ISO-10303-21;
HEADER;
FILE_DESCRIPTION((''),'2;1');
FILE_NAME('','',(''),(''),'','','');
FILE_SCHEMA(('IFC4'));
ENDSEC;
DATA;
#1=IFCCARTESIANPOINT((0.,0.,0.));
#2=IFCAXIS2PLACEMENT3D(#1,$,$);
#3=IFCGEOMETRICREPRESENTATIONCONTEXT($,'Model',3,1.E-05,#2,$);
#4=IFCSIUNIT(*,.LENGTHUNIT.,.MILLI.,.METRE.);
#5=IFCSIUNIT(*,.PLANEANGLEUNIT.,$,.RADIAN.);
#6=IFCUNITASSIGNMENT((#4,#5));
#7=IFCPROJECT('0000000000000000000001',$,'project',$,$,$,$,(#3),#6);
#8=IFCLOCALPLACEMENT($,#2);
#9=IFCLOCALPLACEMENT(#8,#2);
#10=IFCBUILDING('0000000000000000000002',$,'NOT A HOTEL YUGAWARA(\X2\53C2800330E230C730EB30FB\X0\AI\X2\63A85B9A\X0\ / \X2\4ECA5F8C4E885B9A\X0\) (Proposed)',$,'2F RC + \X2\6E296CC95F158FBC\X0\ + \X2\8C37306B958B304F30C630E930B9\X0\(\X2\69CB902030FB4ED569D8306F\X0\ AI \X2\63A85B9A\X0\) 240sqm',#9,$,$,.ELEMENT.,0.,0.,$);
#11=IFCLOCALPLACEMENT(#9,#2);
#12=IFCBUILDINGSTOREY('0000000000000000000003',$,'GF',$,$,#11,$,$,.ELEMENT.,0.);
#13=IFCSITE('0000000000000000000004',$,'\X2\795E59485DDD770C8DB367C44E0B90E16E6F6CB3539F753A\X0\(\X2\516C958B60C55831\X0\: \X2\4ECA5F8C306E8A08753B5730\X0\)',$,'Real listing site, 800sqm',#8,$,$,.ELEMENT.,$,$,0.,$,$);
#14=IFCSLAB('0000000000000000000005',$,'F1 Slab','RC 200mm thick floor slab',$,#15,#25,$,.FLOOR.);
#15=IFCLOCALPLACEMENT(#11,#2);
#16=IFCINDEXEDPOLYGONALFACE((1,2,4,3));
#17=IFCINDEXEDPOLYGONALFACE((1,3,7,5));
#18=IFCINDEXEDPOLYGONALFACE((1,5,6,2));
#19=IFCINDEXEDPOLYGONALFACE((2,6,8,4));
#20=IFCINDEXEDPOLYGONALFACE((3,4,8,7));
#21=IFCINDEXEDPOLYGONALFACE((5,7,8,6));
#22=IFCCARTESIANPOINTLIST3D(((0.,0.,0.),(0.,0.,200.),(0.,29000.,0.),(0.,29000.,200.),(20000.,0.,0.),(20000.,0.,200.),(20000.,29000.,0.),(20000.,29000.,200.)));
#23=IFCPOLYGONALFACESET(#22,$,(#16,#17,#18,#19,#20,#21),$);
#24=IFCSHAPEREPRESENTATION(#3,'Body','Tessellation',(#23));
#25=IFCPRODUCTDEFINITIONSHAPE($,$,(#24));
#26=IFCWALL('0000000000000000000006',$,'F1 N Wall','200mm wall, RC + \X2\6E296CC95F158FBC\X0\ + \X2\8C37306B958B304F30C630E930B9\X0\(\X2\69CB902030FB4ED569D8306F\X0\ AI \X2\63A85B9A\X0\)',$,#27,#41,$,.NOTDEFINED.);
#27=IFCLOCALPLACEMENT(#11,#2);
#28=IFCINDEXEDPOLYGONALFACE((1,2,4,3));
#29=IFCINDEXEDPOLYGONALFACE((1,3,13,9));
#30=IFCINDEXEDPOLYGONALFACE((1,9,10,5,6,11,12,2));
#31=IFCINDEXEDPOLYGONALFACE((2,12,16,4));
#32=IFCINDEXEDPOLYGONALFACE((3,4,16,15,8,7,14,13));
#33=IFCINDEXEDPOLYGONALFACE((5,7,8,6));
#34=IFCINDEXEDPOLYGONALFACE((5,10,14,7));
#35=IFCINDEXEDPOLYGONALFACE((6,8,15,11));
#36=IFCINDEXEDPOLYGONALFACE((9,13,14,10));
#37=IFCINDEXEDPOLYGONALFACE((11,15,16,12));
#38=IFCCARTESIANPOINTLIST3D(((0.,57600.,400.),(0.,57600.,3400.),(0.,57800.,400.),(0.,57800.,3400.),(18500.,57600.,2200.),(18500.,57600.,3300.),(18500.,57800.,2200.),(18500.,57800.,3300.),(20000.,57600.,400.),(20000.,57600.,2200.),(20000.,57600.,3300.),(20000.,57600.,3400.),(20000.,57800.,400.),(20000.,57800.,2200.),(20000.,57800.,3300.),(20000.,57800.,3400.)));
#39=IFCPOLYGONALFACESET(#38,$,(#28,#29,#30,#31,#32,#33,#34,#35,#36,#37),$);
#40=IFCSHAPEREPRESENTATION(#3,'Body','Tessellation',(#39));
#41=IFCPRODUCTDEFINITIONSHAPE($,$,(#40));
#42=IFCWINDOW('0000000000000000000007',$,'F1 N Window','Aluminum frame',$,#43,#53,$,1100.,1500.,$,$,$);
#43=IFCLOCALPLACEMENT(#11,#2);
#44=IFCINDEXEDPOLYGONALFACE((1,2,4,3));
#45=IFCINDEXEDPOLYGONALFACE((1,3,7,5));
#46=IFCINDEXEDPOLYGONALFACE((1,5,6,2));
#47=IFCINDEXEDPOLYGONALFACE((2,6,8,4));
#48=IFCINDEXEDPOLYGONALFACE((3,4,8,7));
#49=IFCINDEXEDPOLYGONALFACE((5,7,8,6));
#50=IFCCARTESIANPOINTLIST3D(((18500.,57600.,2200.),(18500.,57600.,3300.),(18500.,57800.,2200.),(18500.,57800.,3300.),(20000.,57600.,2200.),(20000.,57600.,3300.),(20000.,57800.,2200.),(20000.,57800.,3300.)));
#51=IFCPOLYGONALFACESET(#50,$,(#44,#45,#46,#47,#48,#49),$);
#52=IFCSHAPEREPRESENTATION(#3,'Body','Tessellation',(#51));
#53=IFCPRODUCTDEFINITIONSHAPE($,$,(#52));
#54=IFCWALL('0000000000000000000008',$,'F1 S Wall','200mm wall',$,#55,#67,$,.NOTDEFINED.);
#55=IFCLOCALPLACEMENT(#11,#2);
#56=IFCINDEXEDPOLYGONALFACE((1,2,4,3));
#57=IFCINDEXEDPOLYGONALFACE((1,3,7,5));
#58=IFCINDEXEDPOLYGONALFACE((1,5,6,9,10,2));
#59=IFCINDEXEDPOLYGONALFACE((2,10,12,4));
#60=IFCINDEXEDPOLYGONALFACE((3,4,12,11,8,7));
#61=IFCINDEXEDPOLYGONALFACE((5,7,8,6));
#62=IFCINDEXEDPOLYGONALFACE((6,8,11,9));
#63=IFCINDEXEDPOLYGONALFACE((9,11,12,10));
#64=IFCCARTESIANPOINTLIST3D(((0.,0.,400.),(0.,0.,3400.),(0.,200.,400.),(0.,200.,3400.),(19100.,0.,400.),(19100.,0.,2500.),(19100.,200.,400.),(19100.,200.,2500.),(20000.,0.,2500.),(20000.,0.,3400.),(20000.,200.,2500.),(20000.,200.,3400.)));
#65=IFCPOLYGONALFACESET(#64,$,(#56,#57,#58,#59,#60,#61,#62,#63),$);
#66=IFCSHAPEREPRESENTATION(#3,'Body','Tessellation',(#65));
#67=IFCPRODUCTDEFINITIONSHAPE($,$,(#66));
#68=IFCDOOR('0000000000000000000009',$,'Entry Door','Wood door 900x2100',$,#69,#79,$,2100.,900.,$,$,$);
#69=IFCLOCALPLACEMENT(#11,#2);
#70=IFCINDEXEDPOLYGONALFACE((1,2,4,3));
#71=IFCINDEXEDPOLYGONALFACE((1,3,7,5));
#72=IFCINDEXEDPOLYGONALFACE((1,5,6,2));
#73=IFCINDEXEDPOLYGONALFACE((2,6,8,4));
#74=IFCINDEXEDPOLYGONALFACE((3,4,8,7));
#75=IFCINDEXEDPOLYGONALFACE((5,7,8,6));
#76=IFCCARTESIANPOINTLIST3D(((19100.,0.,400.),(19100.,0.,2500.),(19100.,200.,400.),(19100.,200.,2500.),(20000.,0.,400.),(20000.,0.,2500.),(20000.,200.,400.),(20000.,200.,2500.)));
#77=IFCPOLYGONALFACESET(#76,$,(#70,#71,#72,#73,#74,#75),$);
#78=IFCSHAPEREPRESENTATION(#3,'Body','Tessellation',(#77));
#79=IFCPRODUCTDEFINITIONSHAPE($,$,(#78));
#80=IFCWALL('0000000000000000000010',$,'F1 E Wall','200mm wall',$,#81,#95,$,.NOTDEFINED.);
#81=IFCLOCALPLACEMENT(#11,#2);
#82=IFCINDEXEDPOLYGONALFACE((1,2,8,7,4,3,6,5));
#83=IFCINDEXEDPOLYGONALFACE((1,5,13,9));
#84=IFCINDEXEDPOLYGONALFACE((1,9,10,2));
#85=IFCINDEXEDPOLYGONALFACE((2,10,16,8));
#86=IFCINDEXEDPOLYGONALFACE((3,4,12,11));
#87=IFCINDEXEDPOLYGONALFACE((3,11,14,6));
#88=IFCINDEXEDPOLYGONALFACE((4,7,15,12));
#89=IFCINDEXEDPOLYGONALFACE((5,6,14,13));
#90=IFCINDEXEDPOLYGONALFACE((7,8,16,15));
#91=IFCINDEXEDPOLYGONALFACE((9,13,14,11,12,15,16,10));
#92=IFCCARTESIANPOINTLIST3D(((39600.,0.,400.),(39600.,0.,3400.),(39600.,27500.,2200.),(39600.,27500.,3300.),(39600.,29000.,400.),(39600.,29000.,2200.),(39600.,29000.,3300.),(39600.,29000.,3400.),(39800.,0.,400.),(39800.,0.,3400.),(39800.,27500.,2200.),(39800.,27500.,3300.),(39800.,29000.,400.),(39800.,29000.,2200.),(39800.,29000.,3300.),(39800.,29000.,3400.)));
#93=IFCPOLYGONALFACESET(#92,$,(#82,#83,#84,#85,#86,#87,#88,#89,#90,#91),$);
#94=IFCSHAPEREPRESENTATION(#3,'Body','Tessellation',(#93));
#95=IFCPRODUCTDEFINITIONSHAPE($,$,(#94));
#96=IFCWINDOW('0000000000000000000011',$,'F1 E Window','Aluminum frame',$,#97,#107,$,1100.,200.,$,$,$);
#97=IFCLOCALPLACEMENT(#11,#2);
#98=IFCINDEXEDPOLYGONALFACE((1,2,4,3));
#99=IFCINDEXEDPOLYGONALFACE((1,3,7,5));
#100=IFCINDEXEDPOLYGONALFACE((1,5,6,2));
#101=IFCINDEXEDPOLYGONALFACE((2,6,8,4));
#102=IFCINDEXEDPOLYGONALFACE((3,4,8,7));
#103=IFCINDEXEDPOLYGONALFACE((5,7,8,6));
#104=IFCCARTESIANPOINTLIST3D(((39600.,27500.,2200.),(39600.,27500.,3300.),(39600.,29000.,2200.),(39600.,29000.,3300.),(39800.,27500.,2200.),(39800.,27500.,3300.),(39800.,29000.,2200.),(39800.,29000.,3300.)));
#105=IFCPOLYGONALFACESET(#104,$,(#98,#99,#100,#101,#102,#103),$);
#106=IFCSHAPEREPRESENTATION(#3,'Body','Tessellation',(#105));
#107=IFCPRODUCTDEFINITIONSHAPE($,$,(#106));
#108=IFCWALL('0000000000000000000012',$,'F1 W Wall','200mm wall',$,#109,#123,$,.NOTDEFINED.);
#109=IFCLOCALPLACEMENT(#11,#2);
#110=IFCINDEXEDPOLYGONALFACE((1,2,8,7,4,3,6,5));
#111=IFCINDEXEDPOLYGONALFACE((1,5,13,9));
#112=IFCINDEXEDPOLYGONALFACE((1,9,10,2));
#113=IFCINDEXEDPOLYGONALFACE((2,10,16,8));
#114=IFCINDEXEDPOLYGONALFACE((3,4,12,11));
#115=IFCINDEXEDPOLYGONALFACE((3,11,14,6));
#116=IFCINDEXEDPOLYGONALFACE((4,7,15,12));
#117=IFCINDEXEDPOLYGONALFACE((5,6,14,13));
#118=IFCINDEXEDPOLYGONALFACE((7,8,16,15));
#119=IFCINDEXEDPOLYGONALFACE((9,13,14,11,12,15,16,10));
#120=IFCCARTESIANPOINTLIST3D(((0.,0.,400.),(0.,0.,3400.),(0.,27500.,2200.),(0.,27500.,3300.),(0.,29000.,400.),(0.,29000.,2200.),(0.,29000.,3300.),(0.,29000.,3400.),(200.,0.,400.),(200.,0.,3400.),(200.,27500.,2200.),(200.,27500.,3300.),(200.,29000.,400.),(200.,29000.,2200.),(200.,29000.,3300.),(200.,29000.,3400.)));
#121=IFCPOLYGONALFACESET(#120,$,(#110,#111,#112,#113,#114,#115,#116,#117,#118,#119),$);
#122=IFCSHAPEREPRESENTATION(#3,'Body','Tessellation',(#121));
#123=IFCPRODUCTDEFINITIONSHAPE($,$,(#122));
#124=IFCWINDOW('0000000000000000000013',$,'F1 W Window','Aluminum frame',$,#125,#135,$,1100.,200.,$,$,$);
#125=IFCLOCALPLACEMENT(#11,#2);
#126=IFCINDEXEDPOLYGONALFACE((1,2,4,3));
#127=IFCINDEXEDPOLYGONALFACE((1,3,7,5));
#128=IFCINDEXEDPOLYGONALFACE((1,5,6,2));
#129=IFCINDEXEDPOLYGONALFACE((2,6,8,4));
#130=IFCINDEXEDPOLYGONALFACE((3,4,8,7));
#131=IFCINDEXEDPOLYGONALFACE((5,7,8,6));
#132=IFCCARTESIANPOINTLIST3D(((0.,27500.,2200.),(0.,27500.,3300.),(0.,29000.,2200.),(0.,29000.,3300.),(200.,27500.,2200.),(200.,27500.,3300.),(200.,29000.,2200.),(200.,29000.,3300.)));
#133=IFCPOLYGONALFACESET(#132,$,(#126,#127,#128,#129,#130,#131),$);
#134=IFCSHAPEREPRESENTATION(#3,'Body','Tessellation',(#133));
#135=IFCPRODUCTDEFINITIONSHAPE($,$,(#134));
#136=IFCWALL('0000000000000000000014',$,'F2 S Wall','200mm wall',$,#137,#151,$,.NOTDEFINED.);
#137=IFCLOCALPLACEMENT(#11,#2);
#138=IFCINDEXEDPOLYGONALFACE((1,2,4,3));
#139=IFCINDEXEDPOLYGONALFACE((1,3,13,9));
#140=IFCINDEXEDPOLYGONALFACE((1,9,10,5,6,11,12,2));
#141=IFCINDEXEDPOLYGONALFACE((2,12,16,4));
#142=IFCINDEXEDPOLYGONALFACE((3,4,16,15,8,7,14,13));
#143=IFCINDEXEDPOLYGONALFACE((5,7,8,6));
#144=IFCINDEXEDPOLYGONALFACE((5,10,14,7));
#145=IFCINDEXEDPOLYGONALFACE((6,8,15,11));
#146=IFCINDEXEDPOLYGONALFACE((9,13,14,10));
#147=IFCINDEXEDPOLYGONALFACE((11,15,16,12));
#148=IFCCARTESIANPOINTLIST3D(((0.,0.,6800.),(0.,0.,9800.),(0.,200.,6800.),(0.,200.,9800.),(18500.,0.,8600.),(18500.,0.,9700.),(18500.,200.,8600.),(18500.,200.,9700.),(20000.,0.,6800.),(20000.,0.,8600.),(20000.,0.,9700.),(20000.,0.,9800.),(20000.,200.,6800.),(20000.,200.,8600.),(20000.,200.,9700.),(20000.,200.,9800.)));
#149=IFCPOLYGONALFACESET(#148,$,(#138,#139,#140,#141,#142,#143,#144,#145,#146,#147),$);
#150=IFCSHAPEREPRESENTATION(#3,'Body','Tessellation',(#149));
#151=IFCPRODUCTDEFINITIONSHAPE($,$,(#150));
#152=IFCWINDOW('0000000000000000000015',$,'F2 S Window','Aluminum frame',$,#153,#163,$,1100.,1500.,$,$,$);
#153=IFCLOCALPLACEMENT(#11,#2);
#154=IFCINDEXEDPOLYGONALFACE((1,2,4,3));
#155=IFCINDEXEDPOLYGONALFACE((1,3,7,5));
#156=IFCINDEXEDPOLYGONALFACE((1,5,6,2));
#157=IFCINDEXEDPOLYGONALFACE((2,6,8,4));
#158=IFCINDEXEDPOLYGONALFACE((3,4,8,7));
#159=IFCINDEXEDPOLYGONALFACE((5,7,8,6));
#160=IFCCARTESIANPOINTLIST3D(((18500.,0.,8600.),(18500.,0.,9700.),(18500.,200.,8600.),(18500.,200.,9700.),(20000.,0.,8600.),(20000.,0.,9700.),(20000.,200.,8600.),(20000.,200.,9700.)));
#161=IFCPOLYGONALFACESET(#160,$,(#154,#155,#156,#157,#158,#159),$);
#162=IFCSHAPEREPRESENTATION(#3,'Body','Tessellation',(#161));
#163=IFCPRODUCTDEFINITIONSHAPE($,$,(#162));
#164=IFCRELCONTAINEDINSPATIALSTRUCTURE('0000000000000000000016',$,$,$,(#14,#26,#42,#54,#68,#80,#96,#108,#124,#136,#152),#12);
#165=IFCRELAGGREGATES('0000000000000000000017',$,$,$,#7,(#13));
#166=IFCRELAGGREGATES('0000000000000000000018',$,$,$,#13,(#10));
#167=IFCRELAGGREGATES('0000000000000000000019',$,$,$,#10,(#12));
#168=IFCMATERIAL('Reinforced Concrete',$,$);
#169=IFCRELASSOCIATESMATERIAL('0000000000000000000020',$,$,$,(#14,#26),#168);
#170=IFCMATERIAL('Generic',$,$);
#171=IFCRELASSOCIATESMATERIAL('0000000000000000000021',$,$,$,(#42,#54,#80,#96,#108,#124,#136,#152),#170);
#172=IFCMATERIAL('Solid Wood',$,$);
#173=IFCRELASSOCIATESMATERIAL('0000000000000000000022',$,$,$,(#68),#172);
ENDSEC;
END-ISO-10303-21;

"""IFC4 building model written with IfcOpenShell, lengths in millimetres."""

from ifc_helpers import new_model, si_unit, frame, frame_2d, origin, place, context, project, spatial, rectangle, extrude, material, element, fill, save


model = new_model("IFC4")

# Units and contexts
model_context = context("Model", 3, precision=1e-05, world=origin())
ifc_project = project(units=[si_unit("LENGTHUNIT", "METRE", prefix="MILLI"), si_unit("PLANEANGLEUNIT", "RADIAN")], contexts=[model_context])

# Site, building, storey
site_placement = place(None, origin())
site = spatial("IfcSite", under=ifc_project, at=site_placement, Name="神奈川県足柄下郡湯河原町(公開情報: 今後の計画地)", ObjectType="Real listing site, 800sqm", CompositionType="ELEMENT", RefElevation=0.0)
building_placement = place(site_placement, origin())
building = spatial("IfcBuilding", under=site, at=building_placement, Name="NOT A HOTEL YUGAWARA(参考モデル・AI推定 / 今後予定) (Proposed)", ObjectType="2F RC + 温泉引込 + 谷に開くテラス(構造・仕様は AI 推定) 240sqm", CompositionType="ELEMENT", ElevationOfRefHeight=0.0, ElevationOfTerrain=0.0)
storey_placement = place(building_placement, origin())
storey = spatial("IfcBuildingStorey", under=building, at=storey_placement, Name="GF", CompositionType="ELEMENT", Elevation=0.0)

# Slab
ifc_material_1 = material(Name="Reinforced Concrete")
slab_1_placement = place(storey_placement, origin())
element("IfcSlab", 1, at=slab_1_placement, inside=storey, material=ifc_material_1, Name="F1 Slab", Description="RC 200mm thick floor slab", PredefinedType="FLOOR", context=model_context, shape_type="SweptSolid", body=[
    extrude(rectangle(XDim=20000.0, YDim=29000.0, at=frame_2d((10000.0, 14500.0))), origin(), (0.0, 0.0, 1.0), 200.0),
])

# Wall, opening, window
wall_1_placement = place(storey_placement, frame((0.0, 28800.0, 200.0)))
wall_1 = element("IfcWall", 2, at=wall_1_placement, inside=storey, material=ifc_material_1, Name="F1 N Wall", Description="200mm wall, RC + 温泉引込 + 谷に開くテラス(構造・仕様は AI 推定)", PredefinedType="NOTDEFINED", context=model_context, shape_type="SweptSolid", body=[
    extrude(rectangle(XDim=20000.0, YDim=200.0, at=frame_2d((10000.0, 100.0))), frame((0.0, 28800.0, 200.0)), (0.0, 0.0, 1.0), 3000.0),
])
opening_1_placement = place(storey_placement, frame((9250.0, 28800.0, 1100.0)))
opening_1 = element("IfcOpeningElement", 3, at=opening_1_placement, cuts=wall_1, PredefinedType="NOTDEFINED", context=model_context, shape_type="SweptSolid", body=[
    extrude(rectangle(XDim=1500.0, YDim=200.0, at=frame_2d((750.0, 100.0))), frame((9250.0, 28800.0, 1100.0)), (0.0, 0.0, 1.0), 1100.0),
])
ifc_material_2 = material(Name="Generic")
window_1_placement = place(storey_placement, frame((9250.0, 28800.0, 1100.0)))
window_1 = element("IfcWindow", 4, at=window_1_placement, inside=storey, material=ifc_material_2, Name="F1 N Window", Description="Aluminum frame", OverallHeight=1100.0, OverallWidth=1500.0, context=model_context, shape_type="SweptSolid", body=[
    extrude(rectangle(XDim=1500.0, YDim=200.0, at=frame_2d((750.0, 100.0))), frame((9250.0, 28800.0, 1100.0)), (0.0, 0.0, 1.0), 1100.0),
])
fill(opening_1, window_1)

# Wall, opening, door
wall_2_placement = place(storey_placement, frame((0.0, 0.0, 200.0)))
wall_2 = element("IfcWall", 5, at=wall_2_placement, inside=storey, material=ifc_material_2, Name="F1 S Wall", Description="200mm wall", PredefinedType="NOTDEFINED", context=model_context, shape_type="SweptSolid", body=[
    extrude(rectangle(XDim=20000.0, YDim=200.0, at=frame_2d((10000.0, 100.0))), frame((0.0, 0.0, 200.0)), (0.0, 0.0, 1.0), 3000.0),
])
opening_2_placement = place(storey_placement, frame((9550.0, 0.0, 200.0)))
opening_2 = element("IfcOpeningElement", 6, at=opening_2_placement, cuts=wall_2, PredefinedType="NOTDEFINED", context=model_context, shape_type="SweptSolid", body=[
    extrude(rectangle(XDim=900.0, YDim=200.0, at=frame_2d((450.0, 100.0))), frame((9550.0, 0.0, 200.0)), (0.0, 0.0, 1.0), 2100.0),
])
ifc_material_3 = material(Name="Solid Wood")
door_placement = place(storey_placement, frame((9550.0, 0.0, 200.0)))
door = element("IfcDoor", 7, at=door_placement, inside=storey, material=ifc_material_3, Name="Entry Door", Description="Wood door 900x2100", OverallHeight=2100.0, OverallWidth=900.0, context=model_context, shape_type="SweptSolid", body=[
    extrude(rectangle(XDim=900.0, YDim=200.0, at=frame_2d((450.0, 100.0))), frame((9550.0, 0.0, 200.0)), (0.0, 0.0, 1.0), 2100.0),
])
fill(opening_2, door)

# Walls, openings, windows
wall_3_placement = place(storey_placement, frame((19800.0, 0.0, 200.0)))
wall_3 = element("IfcWall", 8, at=wall_3_placement, inside=storey, material=ifc_material_2, Name="F1 E Wall", Description="200mm wall", PredefinedType="NOTDEFINED", context=model_context, shape_type="SweptSolid", body=[
    extrude(rectangle(XDim=200.0, YDim=29000.0, at=frame_2d((100.0, 14500.0))), frame((19800.0, 0.0, 200.0)), (0.0, 0.0, 1.0), 3000.0),
])
opening_3_placement = place(storey_placement, frame((19800.0, 13750.0, 1100.0)))
opening_3 = element("IfcOpeningElement", 9, at=opening_3_placement, cuts=wall_3, PredefinedType="NOTDEFINED", context=model_context, shape_type="SweptSolid", body=[
    extrude(rectangle(XDim=200.0, YDim=1500.0, at=frame_2d((100.0, 750.0))), frame((19800.0, 13750.0, 1100.0)), (0.0, 0.0, 1.0), 1100.0),
])
window_2_placement = place(storey_placement, frame((19800.0, 13750.0, 1100.0)))
window_2 = element("IfcWindow", 10, at=window_2_placement, inside=storey, material=ifc_material_2, Name="F1 E Window", Description="Aluminum frame", OverallHeight=1100.0, OverallWidth=200.0, context=model_context, shape_type="SweptSolid", body=[
    extrude(rectangle(XDim=200.0, YDim=1500.0, at=frame_2d((100.0, 750.0))), frame((19800.0, 13750.0, 1100.0)), (0.0, 0.0, 1.0), 1100.0),
])
fill(opening_3, window_2)
wall_4_placement = place(storey_placement, frame((0.0, 0.0, 200.0)))
wall_4 = element("IfcWall", 11, at=wall_4_placement, inside=storey, material=ifc_material_2, Name="F1 W Wall", Description="200mm wall", PredefinedType="NOTDEFINED", context=model_context, shape_type="SweptSolid", body=[
    extrude(rectangle(XDim=200.0, YDim=29000.0, at=frame_2d((100.0, 14500.0))), frame((0.0, 0.0, 200.0)), (0.0, 0.0, 1.0), 3000.0),
])
opening_4_placement = place(storey_placement, frame((0.0, 13750.0, 1100.0)))
opening_4 = element("IfcOpeningElement", 12, at=opening_4_placement, cuts=wall_4, PredefinedType="NOTDEFINED", context=model_context, shape_type="SweptSolid", body=[
    extrude(rectangle(XDim=200.0, YDim=1500.0, at=frame_2d((100.0, 750.0))), frame((0.0, 13750.0, 1100.0)), (0.0, 0.0, 1.0), 1100.0),
])
window_3_placement = place(storey_placement, frame((0.0, 13750.0, 1100.0)))
window_3 = element("IfcWindow", 13, at=window_3_placement, inside=storey, material=ifc_material_2, Name="F1 W Window", Description="Aluminum frame", OverallHeight=1100.0, OverallWidth=200.0, context=model_context, shape_type="SweptSolid", body=[
    extrude(rectangle(XDim=200.0, YDim=1500.0, at=frame_2d((100.0, 750.0))), frame((0.0, 13750.0, 1100.0)), (0.0, 0.0, 1.0), 1100.0),
])
fill(opening_4, window_3)
wall_5_placement = place(storey_placement, frame((0.0, 0.0, 3400.0)))
wall_5 = element("IfcWall", 14, at=wall_5_placement, inside=storey, material=ifc_material_2, Name="F2 S Wall", Description="200mm wall", PredefinedType="NOTDEFINED", context=model_context, shape_type="SweptSolid", body=[
    extrude(rectangle(XDim=20000.0, YDim=200.0, at=frame_2d((10000.0, 100.0))), frame((0.0, 0.0, 3400.0)), (0.0, 0.0, 1.0), 3000.0),
])
opening_5_placement = place(storey_placement, frame((9250.0, 0.0, 4300.0)))
opening_5 = element("IfcOpeningElement", 15, at=opening_5_placement, cuts=wall_5, PredefinedType="NOTDEFINED", context=model_context, shape_type="SweptSolid", body=[
    extrude(rectangle(XDim=1500.0, YDim=200.0, at=frame_2d((750.0, 100.0))), frame((9250.0, 0.0, 4300.0)), (0.0, 0.0, 1.0), 1100.0),
])
window_4_placement = place(storey_placement, frame((9250.0, 0.0, 4300.0)))
window_4 = element("IfcWindow", 16, at=window_4_placement, inside=storey, material=ifc_material_2, Name="F2 S Window", Description="Aluminum frame", OverallHeight=1100.0, OverallWidth=1500.0, context=model_context, shape_type="SweptSolid", body=[
    extrude(rectangle(XDim=1500.0, YDim=200.0, at=frame_2d((750.0, 100.0))), frame((9250.0, 0.0, 4300.0)), (0.0, 0.0, 1.0), 1100.0),
])
fill(opening_5, window_4)

save(model, "model.ifc")
